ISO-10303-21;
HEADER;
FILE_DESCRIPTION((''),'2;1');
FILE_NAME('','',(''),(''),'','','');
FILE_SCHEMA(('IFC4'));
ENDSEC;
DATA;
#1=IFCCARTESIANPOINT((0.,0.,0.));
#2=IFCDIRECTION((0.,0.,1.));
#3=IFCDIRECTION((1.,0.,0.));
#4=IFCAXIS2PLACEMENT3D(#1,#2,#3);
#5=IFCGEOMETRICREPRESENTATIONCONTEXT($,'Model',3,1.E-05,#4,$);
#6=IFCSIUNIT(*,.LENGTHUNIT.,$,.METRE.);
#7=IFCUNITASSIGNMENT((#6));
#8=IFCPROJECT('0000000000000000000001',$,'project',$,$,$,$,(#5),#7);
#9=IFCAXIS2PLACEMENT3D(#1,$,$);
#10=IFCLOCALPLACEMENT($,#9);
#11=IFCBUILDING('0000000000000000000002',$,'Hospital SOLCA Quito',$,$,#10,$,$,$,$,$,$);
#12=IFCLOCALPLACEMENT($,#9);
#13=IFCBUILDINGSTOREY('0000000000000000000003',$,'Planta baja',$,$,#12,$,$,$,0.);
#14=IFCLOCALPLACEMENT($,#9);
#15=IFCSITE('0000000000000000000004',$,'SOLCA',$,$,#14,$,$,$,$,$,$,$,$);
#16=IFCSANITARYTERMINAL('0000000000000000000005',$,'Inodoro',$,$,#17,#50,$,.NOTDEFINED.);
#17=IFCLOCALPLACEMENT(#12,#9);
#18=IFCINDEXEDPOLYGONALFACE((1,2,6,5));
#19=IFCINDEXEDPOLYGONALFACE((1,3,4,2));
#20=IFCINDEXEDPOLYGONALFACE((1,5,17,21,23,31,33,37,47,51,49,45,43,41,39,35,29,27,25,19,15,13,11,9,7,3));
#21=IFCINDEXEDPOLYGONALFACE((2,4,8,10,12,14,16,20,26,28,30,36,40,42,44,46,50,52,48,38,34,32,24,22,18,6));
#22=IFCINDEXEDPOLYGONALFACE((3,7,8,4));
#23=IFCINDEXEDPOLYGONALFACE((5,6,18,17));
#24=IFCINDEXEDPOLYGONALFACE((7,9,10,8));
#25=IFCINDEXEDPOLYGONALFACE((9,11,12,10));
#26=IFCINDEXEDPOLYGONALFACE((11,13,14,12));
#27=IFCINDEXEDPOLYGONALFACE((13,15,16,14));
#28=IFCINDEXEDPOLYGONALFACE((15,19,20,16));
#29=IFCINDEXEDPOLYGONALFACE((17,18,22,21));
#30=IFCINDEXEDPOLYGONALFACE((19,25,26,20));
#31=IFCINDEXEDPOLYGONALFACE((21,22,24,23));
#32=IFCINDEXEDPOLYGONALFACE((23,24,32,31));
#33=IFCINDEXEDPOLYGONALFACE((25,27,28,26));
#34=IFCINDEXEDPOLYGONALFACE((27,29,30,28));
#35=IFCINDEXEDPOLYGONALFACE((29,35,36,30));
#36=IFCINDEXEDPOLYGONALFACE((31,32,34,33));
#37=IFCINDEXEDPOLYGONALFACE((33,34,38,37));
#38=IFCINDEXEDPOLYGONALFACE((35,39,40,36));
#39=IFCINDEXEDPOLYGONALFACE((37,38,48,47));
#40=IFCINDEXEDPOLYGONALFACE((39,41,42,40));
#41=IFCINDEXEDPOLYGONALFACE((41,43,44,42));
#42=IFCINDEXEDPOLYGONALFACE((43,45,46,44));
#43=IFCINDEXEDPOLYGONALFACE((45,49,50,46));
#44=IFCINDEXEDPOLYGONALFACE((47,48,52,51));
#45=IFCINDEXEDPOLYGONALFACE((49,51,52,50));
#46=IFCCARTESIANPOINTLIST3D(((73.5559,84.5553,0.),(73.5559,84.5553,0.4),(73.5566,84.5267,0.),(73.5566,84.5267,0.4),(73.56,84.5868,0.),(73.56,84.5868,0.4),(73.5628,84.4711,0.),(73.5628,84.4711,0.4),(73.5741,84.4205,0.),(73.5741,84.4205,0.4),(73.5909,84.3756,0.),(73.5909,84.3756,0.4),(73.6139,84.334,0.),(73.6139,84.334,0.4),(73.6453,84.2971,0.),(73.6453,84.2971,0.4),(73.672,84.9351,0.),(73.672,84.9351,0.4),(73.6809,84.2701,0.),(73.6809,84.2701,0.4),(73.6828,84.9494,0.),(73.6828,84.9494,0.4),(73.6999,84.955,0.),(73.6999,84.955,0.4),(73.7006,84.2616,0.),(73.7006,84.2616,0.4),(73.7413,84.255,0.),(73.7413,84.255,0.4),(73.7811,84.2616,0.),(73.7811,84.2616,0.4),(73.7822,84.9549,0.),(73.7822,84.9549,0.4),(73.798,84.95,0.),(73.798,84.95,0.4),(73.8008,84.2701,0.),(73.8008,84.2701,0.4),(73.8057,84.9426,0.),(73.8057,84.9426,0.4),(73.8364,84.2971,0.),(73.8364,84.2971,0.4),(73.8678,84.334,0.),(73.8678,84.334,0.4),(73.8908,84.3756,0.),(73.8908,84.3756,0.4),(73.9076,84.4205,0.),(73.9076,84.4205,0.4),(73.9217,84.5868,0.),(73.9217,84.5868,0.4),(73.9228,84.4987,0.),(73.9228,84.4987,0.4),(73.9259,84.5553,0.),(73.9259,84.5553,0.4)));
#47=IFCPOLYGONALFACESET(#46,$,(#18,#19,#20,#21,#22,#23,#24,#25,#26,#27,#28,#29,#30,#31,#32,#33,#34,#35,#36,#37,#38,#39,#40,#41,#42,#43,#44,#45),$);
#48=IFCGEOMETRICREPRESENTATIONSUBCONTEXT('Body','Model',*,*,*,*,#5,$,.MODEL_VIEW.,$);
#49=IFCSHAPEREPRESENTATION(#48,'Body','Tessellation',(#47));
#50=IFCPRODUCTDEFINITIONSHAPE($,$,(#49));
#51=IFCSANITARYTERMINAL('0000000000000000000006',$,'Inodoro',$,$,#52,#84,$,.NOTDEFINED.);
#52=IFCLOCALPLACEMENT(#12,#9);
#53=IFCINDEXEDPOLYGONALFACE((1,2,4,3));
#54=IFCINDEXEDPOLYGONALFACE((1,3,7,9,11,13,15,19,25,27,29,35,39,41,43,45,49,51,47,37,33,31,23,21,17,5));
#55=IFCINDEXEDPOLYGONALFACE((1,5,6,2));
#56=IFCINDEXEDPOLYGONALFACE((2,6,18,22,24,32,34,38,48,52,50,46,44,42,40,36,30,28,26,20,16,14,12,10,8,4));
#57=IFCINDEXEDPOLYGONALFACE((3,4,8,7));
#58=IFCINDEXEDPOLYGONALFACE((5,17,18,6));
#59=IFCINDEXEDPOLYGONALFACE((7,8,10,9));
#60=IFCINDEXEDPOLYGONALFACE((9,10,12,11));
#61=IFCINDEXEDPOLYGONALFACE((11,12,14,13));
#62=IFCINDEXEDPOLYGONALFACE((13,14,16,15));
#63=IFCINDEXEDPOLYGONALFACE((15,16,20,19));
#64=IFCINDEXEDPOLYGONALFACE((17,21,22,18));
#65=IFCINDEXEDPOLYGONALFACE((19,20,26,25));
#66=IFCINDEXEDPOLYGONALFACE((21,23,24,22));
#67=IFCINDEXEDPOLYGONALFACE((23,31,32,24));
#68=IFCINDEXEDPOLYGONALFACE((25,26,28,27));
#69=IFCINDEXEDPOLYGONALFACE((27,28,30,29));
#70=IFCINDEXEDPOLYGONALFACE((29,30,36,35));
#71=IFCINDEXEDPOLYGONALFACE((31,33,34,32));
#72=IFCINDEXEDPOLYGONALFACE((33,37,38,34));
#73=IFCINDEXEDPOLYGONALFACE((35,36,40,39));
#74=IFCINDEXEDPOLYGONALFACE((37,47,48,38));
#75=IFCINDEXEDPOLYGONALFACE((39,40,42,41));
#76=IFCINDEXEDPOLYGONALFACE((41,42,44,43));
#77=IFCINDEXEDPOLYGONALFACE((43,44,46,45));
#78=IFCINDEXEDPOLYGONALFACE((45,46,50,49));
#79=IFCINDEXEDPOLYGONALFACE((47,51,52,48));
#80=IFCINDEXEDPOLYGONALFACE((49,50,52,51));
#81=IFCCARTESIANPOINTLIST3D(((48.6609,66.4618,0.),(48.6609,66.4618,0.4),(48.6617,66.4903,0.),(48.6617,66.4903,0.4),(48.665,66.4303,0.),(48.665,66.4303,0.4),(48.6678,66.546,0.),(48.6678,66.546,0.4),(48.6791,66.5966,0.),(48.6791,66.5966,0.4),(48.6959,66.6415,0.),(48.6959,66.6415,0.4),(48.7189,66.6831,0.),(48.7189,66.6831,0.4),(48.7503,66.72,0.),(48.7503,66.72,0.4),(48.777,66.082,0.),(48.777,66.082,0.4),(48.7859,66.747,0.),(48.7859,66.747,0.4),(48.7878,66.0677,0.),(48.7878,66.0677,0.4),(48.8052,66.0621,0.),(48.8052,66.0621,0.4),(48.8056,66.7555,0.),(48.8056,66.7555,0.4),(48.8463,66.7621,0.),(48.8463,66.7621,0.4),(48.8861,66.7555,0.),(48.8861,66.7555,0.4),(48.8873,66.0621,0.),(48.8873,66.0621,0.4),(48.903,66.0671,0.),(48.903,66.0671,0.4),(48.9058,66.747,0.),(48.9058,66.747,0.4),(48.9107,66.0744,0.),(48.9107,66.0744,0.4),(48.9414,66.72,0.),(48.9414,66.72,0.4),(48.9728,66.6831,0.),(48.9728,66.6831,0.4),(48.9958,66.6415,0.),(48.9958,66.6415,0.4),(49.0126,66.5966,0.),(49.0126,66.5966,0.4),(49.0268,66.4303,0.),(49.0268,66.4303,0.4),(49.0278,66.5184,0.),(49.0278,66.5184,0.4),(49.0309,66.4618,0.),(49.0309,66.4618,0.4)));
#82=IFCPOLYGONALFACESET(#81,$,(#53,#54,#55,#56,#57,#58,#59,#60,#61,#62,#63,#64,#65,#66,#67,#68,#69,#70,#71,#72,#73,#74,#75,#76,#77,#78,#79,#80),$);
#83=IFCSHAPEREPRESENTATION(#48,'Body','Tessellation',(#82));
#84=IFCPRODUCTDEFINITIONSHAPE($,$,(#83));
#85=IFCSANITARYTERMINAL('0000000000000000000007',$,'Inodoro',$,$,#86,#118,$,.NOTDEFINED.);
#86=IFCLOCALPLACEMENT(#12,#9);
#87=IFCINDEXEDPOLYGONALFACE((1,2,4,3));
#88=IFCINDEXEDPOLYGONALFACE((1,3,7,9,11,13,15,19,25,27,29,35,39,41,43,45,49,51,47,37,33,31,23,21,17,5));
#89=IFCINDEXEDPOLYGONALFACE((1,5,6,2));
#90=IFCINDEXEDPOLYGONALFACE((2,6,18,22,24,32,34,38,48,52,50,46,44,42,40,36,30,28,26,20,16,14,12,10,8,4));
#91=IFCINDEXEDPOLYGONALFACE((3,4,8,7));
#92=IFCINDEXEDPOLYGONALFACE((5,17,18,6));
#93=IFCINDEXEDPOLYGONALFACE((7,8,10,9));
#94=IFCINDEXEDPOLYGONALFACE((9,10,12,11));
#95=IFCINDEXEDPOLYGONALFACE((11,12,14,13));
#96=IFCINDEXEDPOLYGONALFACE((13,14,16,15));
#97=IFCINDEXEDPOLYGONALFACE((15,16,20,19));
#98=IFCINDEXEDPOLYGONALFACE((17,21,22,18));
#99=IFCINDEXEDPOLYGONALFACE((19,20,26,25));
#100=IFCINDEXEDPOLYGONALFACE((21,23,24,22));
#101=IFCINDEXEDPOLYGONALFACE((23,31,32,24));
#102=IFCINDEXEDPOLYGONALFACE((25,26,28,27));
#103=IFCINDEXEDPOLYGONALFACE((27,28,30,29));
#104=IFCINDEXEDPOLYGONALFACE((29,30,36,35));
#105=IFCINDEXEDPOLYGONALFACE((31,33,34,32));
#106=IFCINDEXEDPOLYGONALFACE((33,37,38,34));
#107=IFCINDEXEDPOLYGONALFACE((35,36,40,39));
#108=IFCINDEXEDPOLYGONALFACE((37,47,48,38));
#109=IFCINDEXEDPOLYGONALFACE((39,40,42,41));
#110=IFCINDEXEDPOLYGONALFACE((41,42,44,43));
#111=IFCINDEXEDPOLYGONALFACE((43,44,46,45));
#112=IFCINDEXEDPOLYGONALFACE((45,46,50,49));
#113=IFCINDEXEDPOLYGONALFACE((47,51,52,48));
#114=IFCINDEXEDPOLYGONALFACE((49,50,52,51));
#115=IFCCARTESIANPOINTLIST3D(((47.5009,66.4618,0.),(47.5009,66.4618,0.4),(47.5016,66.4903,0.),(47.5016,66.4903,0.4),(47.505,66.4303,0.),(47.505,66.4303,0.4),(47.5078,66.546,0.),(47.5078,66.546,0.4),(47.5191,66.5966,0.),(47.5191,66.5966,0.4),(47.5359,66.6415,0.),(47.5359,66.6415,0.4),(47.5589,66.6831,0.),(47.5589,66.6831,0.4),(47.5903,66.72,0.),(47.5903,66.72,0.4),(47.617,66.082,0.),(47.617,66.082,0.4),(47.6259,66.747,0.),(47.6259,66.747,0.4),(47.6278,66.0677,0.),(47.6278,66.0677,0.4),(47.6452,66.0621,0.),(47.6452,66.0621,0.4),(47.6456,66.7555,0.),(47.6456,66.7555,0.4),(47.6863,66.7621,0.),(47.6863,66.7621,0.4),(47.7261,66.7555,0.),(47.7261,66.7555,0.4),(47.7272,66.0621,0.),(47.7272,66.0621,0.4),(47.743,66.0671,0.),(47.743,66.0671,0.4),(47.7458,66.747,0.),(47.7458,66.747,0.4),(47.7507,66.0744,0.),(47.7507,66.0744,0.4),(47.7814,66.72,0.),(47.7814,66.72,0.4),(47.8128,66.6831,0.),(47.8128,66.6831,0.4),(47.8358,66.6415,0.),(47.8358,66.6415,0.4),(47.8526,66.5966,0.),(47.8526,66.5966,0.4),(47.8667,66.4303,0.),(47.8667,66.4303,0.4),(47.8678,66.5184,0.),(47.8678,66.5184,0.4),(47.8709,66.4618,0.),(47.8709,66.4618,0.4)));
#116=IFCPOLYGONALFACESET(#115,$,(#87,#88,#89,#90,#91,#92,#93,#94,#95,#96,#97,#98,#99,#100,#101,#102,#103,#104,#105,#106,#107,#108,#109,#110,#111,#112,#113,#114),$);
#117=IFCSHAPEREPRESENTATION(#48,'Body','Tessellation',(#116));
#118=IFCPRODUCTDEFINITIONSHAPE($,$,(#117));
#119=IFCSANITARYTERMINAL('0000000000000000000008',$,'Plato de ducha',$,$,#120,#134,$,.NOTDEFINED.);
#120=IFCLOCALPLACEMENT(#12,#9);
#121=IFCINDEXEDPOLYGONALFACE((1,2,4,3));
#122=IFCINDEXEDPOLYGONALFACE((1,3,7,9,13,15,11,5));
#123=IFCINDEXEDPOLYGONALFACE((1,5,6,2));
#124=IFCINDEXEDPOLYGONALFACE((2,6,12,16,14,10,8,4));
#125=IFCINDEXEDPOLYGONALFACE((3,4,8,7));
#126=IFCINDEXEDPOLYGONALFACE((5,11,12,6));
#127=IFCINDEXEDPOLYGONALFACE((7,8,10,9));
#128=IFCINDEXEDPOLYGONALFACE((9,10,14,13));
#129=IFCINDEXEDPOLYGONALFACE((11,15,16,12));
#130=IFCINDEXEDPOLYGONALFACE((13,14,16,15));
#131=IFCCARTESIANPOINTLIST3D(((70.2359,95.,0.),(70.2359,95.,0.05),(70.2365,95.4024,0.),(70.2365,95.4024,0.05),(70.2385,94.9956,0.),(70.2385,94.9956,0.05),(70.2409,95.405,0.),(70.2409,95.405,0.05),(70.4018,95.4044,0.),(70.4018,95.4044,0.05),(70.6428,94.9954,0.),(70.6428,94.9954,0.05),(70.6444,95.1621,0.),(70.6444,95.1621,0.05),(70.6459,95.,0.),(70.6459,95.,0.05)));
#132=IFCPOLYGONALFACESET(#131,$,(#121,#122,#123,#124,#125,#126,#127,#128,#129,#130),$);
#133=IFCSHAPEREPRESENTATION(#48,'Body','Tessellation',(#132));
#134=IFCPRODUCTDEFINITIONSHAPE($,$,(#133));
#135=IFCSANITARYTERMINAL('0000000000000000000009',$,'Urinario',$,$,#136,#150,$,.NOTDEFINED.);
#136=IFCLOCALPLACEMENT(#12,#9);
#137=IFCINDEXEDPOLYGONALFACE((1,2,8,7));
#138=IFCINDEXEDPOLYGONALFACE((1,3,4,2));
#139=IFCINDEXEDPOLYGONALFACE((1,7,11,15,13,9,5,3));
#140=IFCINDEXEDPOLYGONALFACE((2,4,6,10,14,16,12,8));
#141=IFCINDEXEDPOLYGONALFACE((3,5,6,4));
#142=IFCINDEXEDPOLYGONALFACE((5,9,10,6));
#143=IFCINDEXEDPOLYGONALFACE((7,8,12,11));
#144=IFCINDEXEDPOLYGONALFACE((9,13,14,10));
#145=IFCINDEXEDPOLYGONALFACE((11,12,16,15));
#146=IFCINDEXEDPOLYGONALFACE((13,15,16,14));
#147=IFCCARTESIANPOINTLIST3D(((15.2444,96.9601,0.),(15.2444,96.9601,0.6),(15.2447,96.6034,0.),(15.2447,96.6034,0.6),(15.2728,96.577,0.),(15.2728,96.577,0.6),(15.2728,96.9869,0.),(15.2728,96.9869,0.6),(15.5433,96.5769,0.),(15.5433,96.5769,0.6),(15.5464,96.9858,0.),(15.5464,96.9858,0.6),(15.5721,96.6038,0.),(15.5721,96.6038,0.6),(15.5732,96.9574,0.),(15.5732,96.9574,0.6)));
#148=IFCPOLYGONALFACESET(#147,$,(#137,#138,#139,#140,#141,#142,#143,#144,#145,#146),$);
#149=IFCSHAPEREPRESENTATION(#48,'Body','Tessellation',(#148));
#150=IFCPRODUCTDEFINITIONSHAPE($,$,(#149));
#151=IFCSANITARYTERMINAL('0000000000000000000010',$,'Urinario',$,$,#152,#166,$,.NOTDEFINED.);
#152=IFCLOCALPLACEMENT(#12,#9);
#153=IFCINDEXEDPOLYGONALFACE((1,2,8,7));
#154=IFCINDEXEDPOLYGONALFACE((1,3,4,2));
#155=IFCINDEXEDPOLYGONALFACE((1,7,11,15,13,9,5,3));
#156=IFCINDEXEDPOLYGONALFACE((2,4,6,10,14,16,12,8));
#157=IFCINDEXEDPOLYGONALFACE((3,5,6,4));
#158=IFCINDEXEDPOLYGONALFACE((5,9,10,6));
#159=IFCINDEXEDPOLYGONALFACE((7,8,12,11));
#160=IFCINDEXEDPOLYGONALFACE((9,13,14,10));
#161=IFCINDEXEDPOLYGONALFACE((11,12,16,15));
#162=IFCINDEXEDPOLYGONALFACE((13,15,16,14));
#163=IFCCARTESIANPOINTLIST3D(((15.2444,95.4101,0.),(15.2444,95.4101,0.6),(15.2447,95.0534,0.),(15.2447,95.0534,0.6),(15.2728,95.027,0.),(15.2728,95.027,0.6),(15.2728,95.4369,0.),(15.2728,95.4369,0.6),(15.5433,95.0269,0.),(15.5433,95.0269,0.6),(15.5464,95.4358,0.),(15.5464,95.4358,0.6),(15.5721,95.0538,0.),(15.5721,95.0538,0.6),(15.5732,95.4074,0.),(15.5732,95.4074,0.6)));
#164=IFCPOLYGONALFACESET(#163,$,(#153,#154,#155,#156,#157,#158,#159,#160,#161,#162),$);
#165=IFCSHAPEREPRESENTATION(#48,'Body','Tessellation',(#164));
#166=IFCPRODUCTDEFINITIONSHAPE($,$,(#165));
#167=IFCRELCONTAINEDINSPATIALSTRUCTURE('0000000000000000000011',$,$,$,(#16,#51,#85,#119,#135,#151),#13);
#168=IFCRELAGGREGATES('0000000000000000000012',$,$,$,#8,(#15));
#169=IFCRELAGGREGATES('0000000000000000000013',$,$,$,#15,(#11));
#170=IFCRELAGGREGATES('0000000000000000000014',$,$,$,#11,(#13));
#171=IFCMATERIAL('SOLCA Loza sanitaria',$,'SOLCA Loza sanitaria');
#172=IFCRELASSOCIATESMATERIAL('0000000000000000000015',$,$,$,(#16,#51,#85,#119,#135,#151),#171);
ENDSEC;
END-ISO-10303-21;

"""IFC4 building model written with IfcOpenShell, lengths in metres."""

from ifc_helpers import new_model, si_unit, origin, origin_with_axes, place, context, subcontext, project, spatial, polyline, outline, extrude, material, element, save


model = new_model("IFC4")

# Units and contexts
model_context = context("Model", 3, precision=1e-05, world=origin_with_axes())
body_context = subcontext(model_context, "Body", "Model", "MODEL_VIEW")
ifc_project = project(units=[si_unit("LENGTHUNIT", "METRE")], contexts=[model_context])

# Site, building, storey
site_placement = place(None, origin())
site = spatial("IfcSite", under=ifc_project, at=site_placement, Name="SOLCA")
building_placement = place(None, origin())
building = spatial("IfcBuilding", under=site, at=building_placement, Name="Hospital SOLCA Quito")
storey_placement = place(None, origin())
storey = spatial("IfcBuildingStorey", under=building, at=storey_placement, Name="Planta baja", Elevation=0.0)

# Sanitary terminals
ifc_material = material(Name="SOLCA Loza sanitaria", Category="SOLCA Loza sanitaria")
sanitary_terminal_1_placement = place(storey_placement, origin_with_axes())
element("IfcSanitaryTerminal", 1, at=sanitary_terminal_1_placement, inside=storey, material=ifc_material, Name="Inodoro", PredefinedType="NOTDEFINED", context=body_context, shape_type="SweptSolid", body=[
    extrude(outline(polyline([(73.7413, 84.255), (73.7006, 84.2616), (73.6809, 84.2701), (73.6453, 84.2971), (73.6139, 84.334), (73.5909, 84.3756), (73.5741, 84.4205), (73.5628, 84.4711), (73.5566, 84.5267), (73.5559, 84.5553), (73.56, 84.5868), (73.672, 84.9351), (73.6828, 84.9494), (73.6999, 84.955), (73.7822, 84.9549), (73.798, 84.95), (73.8057, 84.9426), (73.9217, 84.5868), (73.9259, 84.5553), (73.9228, 84.4987), (73.9076, 84.4205), (73.8908, 84.3756), (73.8678, 84.334), (73.8364, 84.2971), (73.8008, 84.2701), (73.7811, 84.2616), (73.7413, 84.255)])), origin_with_axes(), (0.0, 0.0, 1.0), 0.4),
])
sanitary_terminal_2_placement = place(storey_placement, origin_with_axes())
element("IfcSanitaryTerminal", 2, at=sanitary_terminal_2_placement, inside=storey, material=ifc_material, Name="Inodoro", PredefinedType="NOTDEFINED", context=body_context, shape_type="SweptSolid", body=[
    extrude(outline(polyline([(48.8052, 66.0621), (48.7878, 66.0677), (48.777, 66.082), (48.665, 66.4303), (48.6609, 66.4618), (48.6617, 66.4903), (48.6678, 66.546), (48.6791, 66.5966), (48.6959, 66.6415), (48.7189, 66.6831), (48.7503, 66.72), (48.7859, 66.747), (48.8056, 66.7555), (48.8463, 66.7621), (48.8861, 66.7555), (48.9058, 66.747), (48.9414, 66.72), (48.9728, 66.6831), (48.9958, 66.6415), (49.0126, 66.5966), (49.0278, 66.5184), (49.0309, 66.4618), (49.0268, 66.4303), (48.9107, 66.0744), (48.903, 66.0671), (48.8873, 66.0621), (48.8052, 66.0621)])), origin_with_axes(), (0.0, 0.0, 1.0), 0.4),
])
sanitary_terminal_3_placement = place(storey_placement, origin_with_axes())
element("IfcSanitaryTerminal", 3, at=sanitary_terminal_3_placement, inside=storey, material=ifc_material, Name="Inodoro", PredefinedType="NOTDEFINED", context=body_context, shape_type="SweptSolid", body=[
    extrude(outline(polyline([(47.6452, 66.0621), (47.6278, 66.0677), (47.617, 66.082), (47.505, 66.4303), (47.5009, 66.4618), (47.5016, 66.4903), (47.5078, 66.546), (47.5191, 66.5966), (47.5359, 66.6415), (47.5589, 66.6831), (47.5903, 66.72), (47.6259, 66.747), (47.6456, 66.7555), (47.6863, 66.7621), (47.7261, 66.7555), (47.7458, 66.747), (47.7814, 66.72), (47.8128, 66.6831), (47.8358, 66.6415), (47.8526, 66.5966), (47.8678, 66.5184), (47.8709, 66.4618), (47.8667, 66.4303), (47.7507, 66.0744), (47.743, 66.0671), (47.7272, 66.0621), (47.6452, 66.0621)])), origin_with_axes(), (0.0, 0.0, 1.0), 0.4),
])
sanitary_terminal_4_placement = place(storey_placement, origin_with_axes())
element("IfcSanitaryTerminal", 4, at=sanitary_terminal_4_placement, inside=storey, material=ifc_material, Name="Plato de ducha", PredefinedType="NOTDEFINED", context=body_context, shape_type="SweptSolid", body=[
    extrude(outline(polyline([(70.6444, 95.1621), (70.6459, 95.0), (70.6428, 94.9954), (70.2385, 94.9956), (70.2359, 95.0), (70.2365, 95.4024), (70.2409, 95.405), (70.4018, 95.4044), (70.6444, 95.1621)])), origin_with_axes(), (0.0, 0.0, 1.0), 0.05),
])
sanitary_terminal_5_placement = place(storey_placement, origin_with_axes())
element("IfcSanitaryTerminal", 5, at=sanitary_terminal_5_placement, inside=storey, material=ifc_material, Name="Urinario", PredefinedType="NOTDEFINED", context=body_context, shape_type="SweptSolid", body=[
    extrude(outline(polyline([(15.2447, 96.6034), (15.2444, 96.9601), (15.2728, 96.9869), (15.5464, 96.9858), (15.5732, 96.9574), (15.5721, 96.6038), (15.5433, 96.5769), (15.2728, 96.577), (15.2447, 96.6034)])), origin_with_axes(), (0.0, 0.0, 1.0), 0.6),
])
sanitary_terminal_6_placement = place(storey_placement, origin_with_axes())
element("IfcSanitaryTerminal", 6, at=sanitary_terminal_6_placement, inside=storey, material=ifc_material, Name="Urinario", PredefinedType="NOTDEFINED", context=body_context, shape_type="SweptSolid", body=[
    extrude(outline(polyline([(15.2447, 95.0534), (15.2444, 95.4101), (15.2728, 95.4369), (15.5464, 95.4358), (15.5732, 95.4074), (15.5721, 95.0538), (15.5433, 95.0269), (15.2728, 95.027), (15.2447, 95.0534)])), origin_with_axes(), (0.0, 0.0, 1.0), 0.6),
])

save(model, "model.ifc")
